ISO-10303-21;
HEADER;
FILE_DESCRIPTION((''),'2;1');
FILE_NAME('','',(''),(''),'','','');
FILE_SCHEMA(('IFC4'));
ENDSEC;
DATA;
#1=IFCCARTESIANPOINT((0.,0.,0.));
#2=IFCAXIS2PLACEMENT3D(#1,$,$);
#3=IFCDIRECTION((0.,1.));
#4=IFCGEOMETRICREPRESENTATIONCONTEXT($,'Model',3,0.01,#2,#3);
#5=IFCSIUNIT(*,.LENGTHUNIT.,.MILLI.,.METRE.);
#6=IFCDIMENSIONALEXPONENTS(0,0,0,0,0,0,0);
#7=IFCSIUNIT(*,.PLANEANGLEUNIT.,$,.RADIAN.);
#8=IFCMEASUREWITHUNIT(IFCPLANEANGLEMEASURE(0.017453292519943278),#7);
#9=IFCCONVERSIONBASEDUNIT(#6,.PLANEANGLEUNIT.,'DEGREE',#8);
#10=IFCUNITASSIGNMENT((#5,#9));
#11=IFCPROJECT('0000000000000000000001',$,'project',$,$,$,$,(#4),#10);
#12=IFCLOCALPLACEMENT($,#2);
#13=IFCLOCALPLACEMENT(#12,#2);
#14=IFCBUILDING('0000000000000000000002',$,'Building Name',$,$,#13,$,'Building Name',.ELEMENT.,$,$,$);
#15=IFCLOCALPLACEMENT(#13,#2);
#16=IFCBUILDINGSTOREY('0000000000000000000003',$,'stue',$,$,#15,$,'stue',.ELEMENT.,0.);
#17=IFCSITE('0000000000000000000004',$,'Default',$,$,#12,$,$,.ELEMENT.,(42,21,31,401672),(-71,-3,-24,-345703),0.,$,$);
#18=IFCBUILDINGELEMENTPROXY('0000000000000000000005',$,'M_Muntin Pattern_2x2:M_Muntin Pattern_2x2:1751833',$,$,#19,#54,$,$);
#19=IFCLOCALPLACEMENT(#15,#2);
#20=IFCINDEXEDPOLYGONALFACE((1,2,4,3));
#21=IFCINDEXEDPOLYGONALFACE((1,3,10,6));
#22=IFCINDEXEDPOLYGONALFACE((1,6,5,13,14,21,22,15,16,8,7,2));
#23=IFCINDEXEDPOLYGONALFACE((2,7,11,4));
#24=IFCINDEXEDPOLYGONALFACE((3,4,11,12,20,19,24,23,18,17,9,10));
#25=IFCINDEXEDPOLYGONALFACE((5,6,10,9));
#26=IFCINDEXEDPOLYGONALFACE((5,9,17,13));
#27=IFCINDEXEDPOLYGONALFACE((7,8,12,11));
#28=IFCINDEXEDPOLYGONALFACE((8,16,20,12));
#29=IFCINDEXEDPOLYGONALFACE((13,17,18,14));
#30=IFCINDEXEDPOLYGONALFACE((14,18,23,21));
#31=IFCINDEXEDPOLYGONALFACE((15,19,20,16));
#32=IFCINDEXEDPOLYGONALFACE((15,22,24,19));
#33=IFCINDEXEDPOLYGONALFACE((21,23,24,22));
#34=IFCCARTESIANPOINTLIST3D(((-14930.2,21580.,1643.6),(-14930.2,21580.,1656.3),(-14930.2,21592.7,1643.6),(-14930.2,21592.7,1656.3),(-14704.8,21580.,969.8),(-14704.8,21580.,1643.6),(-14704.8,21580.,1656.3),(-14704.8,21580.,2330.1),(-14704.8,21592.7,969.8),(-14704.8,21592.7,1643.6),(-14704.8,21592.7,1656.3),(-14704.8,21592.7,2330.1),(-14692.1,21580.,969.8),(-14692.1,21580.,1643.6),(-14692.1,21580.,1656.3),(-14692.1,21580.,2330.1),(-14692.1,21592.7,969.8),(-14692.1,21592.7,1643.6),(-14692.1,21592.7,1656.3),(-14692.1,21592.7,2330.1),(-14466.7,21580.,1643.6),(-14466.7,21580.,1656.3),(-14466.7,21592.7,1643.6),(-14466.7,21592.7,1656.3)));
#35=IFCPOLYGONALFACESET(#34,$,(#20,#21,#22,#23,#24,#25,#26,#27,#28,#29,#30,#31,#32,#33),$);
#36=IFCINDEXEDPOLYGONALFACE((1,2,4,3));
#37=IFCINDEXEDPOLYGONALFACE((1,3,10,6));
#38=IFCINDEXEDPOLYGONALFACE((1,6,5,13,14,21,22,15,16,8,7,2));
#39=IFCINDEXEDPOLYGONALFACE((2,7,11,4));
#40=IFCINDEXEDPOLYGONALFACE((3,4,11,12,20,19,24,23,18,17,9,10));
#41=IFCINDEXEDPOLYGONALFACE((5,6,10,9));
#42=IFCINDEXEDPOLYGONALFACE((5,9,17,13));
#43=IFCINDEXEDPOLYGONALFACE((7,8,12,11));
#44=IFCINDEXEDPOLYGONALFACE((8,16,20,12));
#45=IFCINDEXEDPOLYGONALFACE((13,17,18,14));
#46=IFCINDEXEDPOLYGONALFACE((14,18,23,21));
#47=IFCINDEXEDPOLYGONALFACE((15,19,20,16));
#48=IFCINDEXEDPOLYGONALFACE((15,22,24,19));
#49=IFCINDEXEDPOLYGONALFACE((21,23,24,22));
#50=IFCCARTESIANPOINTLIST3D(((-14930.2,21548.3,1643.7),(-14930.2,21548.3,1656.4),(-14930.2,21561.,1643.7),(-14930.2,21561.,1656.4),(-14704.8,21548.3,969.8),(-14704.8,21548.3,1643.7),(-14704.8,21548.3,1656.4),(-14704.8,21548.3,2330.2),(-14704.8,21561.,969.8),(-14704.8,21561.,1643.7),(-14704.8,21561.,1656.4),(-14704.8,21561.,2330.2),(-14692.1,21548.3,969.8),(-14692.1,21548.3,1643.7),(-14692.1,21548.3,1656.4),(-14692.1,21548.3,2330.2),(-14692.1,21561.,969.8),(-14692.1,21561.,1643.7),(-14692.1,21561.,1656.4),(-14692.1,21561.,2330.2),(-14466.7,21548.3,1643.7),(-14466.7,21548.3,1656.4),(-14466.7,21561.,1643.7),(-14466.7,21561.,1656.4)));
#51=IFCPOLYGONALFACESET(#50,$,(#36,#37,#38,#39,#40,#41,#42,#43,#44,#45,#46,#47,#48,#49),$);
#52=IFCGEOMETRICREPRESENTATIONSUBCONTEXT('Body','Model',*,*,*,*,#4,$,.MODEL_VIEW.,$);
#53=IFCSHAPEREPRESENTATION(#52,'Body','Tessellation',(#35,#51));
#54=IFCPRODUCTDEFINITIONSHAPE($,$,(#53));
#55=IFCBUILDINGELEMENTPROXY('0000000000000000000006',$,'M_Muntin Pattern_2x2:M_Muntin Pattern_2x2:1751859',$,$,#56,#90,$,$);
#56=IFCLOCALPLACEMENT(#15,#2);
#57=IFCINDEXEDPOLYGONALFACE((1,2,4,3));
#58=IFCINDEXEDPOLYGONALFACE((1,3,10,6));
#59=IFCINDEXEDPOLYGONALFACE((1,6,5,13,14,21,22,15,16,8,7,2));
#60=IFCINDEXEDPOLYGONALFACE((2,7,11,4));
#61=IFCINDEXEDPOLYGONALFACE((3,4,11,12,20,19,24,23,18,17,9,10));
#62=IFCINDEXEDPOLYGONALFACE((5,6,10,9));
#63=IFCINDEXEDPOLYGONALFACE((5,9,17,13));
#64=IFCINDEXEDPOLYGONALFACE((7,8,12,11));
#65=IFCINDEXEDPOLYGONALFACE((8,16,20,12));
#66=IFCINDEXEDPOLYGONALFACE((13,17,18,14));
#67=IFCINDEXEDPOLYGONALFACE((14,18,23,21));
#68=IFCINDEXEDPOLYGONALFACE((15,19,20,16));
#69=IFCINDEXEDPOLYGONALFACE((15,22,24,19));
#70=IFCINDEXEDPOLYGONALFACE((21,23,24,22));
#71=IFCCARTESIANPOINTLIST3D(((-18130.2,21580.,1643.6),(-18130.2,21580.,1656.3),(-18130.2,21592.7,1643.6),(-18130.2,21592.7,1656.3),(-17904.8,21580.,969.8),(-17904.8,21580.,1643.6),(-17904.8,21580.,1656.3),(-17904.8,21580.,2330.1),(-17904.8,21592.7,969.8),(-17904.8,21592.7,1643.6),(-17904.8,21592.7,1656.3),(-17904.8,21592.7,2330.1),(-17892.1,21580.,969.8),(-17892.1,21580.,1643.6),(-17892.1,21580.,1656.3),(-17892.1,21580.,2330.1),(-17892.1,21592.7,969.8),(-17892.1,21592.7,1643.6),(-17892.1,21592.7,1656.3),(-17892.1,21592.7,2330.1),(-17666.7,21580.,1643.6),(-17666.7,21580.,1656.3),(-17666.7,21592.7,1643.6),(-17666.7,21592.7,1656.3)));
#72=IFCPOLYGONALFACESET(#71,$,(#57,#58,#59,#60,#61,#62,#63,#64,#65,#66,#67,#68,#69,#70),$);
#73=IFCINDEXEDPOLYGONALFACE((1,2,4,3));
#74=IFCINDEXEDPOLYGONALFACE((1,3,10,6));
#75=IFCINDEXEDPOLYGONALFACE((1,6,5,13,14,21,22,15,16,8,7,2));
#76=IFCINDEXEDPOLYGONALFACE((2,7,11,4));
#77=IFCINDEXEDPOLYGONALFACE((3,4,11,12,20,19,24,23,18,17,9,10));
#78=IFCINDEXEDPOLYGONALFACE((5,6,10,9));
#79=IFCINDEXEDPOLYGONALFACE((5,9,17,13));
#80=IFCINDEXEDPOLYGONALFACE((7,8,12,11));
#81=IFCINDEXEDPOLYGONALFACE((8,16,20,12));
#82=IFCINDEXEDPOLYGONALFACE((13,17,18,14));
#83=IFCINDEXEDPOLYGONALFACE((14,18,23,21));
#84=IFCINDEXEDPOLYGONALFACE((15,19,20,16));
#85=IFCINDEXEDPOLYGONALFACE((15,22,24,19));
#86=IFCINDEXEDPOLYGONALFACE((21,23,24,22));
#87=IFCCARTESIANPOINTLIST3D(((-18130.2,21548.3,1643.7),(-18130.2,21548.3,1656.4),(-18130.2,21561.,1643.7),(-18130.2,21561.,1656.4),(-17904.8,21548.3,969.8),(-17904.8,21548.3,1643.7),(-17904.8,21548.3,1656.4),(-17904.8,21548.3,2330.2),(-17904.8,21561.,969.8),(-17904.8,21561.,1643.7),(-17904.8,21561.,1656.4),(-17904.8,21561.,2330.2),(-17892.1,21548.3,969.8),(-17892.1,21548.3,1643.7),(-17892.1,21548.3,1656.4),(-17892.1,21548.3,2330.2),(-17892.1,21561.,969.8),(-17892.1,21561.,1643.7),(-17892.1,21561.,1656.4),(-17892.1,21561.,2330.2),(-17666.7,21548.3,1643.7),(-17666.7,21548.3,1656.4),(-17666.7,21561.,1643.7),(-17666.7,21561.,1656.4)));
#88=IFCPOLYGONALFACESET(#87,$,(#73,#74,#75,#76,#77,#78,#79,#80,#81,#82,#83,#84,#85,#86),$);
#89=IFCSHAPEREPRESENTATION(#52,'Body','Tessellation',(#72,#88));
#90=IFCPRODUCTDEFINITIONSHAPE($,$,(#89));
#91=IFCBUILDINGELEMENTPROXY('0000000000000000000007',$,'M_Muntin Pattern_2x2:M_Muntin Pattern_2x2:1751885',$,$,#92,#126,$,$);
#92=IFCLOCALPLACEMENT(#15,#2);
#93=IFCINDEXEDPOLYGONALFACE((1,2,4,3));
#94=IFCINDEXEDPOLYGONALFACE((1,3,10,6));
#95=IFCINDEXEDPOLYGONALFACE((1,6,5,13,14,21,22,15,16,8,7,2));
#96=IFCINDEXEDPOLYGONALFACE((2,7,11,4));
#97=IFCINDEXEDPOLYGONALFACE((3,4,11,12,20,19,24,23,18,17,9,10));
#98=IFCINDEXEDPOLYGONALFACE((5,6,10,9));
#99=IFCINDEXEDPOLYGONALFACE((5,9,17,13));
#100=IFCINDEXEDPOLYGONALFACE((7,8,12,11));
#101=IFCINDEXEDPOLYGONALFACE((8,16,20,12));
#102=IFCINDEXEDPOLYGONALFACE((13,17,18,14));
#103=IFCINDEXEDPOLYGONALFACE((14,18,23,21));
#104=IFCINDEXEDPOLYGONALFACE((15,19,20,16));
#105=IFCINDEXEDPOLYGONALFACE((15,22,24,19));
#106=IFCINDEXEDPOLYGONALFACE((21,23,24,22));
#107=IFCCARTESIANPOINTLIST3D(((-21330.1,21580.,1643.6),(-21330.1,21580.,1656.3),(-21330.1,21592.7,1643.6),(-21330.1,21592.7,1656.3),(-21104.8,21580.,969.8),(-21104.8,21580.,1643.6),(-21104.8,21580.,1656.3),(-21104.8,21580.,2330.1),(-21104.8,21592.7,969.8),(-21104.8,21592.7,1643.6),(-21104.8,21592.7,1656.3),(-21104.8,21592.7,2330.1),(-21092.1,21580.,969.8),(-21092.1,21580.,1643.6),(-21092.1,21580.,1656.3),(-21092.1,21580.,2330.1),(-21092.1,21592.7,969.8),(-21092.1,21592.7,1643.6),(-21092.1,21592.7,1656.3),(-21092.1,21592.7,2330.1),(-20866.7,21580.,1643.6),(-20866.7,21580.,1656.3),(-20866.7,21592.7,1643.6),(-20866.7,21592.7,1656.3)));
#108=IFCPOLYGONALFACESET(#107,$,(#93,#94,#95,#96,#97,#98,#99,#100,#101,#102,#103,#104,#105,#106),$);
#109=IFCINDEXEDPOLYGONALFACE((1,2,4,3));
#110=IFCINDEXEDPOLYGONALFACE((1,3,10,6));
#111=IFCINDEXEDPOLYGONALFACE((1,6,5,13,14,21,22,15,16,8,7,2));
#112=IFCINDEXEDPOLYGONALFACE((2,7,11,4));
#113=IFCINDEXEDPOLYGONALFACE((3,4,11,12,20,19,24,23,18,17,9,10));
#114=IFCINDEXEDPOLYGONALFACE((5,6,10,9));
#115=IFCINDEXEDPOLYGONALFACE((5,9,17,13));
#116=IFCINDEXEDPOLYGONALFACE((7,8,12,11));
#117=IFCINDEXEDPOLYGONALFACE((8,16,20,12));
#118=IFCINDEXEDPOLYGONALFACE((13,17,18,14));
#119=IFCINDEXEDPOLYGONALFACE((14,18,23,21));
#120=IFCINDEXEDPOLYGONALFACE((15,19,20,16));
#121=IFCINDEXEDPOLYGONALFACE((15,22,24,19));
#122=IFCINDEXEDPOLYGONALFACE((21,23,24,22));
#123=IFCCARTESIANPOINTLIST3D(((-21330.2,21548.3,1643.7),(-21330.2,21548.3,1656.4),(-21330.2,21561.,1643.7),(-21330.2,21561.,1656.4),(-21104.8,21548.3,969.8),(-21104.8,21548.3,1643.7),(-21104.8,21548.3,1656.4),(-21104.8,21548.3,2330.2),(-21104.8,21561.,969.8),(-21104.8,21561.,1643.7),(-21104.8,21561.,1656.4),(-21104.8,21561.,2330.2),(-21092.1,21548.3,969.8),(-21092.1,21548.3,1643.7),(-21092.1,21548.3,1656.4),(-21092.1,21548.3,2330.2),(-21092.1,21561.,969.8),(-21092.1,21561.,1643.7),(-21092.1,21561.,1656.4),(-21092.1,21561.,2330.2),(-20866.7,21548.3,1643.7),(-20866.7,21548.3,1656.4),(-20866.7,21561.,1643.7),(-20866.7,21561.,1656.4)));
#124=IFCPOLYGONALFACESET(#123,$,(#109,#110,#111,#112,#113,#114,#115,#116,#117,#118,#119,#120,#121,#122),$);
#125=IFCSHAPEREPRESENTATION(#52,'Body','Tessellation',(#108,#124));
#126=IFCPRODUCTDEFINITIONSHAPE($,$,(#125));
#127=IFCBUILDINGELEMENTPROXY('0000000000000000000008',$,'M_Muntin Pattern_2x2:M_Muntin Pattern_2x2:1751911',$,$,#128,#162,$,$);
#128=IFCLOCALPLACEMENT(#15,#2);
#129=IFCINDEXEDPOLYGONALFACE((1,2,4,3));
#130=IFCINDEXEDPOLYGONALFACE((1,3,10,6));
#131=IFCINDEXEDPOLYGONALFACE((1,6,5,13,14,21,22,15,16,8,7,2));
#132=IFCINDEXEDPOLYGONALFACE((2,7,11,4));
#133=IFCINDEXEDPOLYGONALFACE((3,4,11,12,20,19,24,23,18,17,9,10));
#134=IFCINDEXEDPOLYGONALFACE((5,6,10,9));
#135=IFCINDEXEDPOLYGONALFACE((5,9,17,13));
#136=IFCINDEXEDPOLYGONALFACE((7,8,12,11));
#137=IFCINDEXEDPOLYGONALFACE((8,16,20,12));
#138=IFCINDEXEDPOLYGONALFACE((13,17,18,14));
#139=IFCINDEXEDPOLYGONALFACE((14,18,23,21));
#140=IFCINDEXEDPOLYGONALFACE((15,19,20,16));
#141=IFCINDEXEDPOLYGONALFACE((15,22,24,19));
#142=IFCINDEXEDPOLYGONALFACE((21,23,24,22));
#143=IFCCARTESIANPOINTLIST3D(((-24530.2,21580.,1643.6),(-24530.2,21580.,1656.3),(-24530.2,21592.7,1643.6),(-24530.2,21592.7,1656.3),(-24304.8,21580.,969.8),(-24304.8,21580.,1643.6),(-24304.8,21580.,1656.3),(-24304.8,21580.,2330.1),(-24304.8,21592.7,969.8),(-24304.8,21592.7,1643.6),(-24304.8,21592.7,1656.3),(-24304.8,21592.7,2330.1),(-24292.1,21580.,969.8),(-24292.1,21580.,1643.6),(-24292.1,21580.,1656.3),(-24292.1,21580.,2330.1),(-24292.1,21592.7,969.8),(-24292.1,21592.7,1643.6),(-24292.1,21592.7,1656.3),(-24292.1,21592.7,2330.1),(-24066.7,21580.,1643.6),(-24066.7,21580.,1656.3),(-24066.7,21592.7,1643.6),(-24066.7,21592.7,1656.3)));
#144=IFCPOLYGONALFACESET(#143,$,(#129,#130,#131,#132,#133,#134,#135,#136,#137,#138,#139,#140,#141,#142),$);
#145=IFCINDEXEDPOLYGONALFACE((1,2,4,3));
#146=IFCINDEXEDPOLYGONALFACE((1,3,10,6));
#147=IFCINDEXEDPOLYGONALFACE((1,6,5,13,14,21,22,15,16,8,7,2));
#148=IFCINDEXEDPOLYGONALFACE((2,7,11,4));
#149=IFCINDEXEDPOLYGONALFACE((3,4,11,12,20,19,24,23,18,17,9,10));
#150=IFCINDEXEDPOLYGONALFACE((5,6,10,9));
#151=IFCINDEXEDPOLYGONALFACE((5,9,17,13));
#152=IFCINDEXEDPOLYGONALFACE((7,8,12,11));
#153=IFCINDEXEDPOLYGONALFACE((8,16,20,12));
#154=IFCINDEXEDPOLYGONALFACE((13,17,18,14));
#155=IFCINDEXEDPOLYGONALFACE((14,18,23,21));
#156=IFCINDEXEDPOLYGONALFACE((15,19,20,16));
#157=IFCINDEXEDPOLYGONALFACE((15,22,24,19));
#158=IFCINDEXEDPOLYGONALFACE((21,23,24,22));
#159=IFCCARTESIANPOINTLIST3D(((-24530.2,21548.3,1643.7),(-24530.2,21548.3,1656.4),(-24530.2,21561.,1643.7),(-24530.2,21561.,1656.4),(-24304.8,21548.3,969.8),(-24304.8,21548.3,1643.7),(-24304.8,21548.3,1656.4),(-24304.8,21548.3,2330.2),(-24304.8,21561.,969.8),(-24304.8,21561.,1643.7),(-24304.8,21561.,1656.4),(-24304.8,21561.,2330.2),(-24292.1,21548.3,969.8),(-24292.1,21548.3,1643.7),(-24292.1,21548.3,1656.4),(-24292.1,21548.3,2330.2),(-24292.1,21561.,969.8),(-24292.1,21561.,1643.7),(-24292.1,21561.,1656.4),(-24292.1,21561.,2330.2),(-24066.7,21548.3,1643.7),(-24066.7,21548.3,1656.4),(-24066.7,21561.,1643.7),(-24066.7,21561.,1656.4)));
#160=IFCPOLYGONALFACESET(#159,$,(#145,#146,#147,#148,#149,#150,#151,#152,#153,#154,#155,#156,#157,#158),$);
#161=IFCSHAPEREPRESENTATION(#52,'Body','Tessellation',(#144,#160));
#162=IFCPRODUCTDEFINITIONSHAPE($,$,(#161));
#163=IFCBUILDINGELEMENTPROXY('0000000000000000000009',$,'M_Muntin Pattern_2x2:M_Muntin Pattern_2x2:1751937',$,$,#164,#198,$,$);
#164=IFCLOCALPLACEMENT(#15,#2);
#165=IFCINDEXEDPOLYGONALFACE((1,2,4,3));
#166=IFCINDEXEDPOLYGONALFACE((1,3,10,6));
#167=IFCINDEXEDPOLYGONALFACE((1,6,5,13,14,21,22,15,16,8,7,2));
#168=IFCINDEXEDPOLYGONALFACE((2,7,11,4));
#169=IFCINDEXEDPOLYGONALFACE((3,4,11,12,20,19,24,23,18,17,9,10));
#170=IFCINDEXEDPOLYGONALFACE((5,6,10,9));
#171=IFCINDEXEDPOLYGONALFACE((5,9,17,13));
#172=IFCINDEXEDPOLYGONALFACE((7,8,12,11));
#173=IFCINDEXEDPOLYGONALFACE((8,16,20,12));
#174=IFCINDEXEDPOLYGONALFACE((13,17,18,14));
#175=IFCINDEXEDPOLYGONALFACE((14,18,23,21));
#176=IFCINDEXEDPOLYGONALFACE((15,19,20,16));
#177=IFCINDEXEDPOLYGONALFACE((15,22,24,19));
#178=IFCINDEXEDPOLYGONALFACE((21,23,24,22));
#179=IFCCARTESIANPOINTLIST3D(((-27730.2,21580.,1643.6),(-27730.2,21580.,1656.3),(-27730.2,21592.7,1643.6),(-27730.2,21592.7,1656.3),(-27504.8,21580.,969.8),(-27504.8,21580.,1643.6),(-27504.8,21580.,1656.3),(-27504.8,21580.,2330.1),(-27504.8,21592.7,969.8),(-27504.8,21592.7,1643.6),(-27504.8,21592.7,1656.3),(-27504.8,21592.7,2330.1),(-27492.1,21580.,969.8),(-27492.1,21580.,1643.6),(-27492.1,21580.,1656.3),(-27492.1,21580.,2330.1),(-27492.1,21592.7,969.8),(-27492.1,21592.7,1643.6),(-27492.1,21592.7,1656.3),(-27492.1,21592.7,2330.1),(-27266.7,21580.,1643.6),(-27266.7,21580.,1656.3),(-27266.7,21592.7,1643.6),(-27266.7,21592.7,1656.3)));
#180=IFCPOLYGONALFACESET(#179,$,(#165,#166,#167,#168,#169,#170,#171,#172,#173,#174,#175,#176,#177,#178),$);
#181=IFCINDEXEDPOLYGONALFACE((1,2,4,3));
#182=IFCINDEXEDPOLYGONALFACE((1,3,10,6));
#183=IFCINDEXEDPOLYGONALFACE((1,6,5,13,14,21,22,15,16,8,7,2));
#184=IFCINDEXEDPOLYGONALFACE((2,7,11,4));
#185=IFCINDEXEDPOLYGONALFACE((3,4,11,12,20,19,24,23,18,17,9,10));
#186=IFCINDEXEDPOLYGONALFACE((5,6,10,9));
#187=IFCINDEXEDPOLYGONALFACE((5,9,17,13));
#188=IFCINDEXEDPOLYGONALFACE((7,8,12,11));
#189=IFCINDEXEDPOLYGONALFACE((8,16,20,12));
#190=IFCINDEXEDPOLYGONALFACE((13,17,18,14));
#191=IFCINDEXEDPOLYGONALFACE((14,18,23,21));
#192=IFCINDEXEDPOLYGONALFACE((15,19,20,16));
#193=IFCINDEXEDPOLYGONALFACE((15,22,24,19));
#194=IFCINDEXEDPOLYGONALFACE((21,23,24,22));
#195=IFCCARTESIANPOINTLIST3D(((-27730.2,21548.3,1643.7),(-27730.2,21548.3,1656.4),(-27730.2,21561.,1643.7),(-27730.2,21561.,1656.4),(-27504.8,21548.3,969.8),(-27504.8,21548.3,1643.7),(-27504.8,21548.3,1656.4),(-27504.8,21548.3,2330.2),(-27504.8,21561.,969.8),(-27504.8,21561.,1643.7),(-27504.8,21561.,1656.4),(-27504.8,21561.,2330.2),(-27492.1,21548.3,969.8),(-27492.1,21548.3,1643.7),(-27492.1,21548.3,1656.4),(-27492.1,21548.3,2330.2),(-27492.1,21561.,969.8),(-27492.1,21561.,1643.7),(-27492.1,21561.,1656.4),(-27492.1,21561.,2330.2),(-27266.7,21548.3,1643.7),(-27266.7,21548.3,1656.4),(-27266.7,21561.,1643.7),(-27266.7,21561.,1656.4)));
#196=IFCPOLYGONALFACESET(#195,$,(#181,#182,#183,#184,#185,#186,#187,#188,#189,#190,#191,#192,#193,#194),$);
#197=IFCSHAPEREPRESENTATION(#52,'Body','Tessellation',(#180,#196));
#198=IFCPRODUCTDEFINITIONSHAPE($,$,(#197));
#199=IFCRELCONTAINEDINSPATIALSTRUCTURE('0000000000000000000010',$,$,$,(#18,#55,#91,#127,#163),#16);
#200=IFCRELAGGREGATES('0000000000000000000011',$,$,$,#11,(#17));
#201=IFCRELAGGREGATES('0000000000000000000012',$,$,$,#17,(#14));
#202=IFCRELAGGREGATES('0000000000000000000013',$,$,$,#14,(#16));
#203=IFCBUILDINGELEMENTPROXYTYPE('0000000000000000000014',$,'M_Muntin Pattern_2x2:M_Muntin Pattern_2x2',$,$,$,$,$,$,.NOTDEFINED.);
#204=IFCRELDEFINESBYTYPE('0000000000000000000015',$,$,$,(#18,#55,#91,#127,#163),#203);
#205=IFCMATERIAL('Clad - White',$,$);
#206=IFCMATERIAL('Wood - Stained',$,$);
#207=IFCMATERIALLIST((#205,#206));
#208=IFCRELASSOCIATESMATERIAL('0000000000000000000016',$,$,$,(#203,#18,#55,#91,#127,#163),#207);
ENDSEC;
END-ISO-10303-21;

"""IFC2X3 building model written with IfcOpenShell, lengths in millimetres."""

from ifc_helpers import new_model, entity, si_unit, converted_unit, direction, frame, origin, place, context, subcontext, project, spatial, polyline, outline, extrude, source, transform, mapped, material, material_list, type_object, type_shapes, element, save


model = new_model("IFC2X3")

# Units and contexts
model_context = context("Model", 3, precision=0.01, world=origin(), true_north=direction((0.0, 1.0)))
body_context = subcontext(model_context, "Body", "Model", "MODEL_VIEW")
ifc_project = project(units=[si_unit("LENGTHUNIT", "METRE", prefix="MILLI"), converted_unit("PLANEANGLEUNIT", "DEGREE", entity("IfcPlaneAngleMeasure", 0.017453292519943278), si_unit("PLANEANGLEUNIT", "RADIAN"), dimensions=[0, 0, 0, 0, 0, 0, 0])], contexts=[model_context])

# Site, building, storey
site_placement = place(None, origin())
site = spatial("IfcSite", under=ifc_project, at=site_placement, Name="Default", CompositionType="ELEMENT", RefLatitude=(42, 21, 31, 401672), RefLongitude=(-71, -3, -24, -345703), RefElevation=0.0)
building_placement = place(site_placement, origin())
building = spatial("IfcBuilding", under=site, at=building_placement, Name="Building Name", LongName="Building Name", CompositionType="ELEMENT")
storey_placement = place(building_placement, origin())
storey = spatial("IfcBuildingStorey", under=building, at=storey_placement, Name="stue", LongName="stue", CompositionType="ELEMENT", Elevation=0.0)

# Building element proxies
ifc_material_1 = material(Name="Clad - White")
ifc_material_2 = material(Name="Wood - Stained")
ifc_material_list = material_list([ifc_material_1, ifc_material_2])
building_element_proxy_type_1 = type_object("IfcBuildingElementProxyType", Name="M_Muntin Pattern_2x2:M_Muntin Pattern_2x2", PredefinedType="NOTDEFINED", material=ifc_material_list)
shared_shape_1 = source(origin(), body_context, "Body", "SweptSolid", [
    extrude(outline(polyline([(6.4, -6.4), (680.1, -6.4), (680.1, 6.3), (6.4, 6.3), (6.4, 231.7), (-6.3, 231.7), (-6.3, 6.3), (-680.2, 6.3), (-680.2, -6.4), (-6.3, -6.4), (-6.3, -231.7), (6.4, -231.7), (6.4, -6.4)])), frame((0.0, 9.5, 680.1), z_axis=(0.0, 1.0, 0.0), x_axis=(0.0, 0.0, 1.0)), (0.0, 0.0, 1.0), 12.7),
    extrude(outline(polyline([(6.4, -6.4), (680.2, -6.4), (680.2, 6.3), (6.4, 6.3), (6.4, 231.7), (-6.3, 231.7), (-6.3, 6.3), (-680.2, 6.3), (-680.2, -6.4), (-6.3, -6.4), (-6.3, -231.7), (6.4, -231.7), (6.4, -6.4)])), frame((0.0, -22.2, 680.2), z_axis=(0.0, 1.0, 0.0), x_axis=(0.0, 0.0, 1.0)), (0.0, 0.0, 1.0), 12.7),
])
type_shapes(building_element_proxy_type_1, [shared_shape_1])
for number, where, name in (
    (1, (-14698.4, 21570.5, 969.8), "M_Muntin Pattern_2x2:M_Muntin Pattern_2x2:1751833"),
    (2, (-17898.4, 21570.5, 969.8), "M_Muntin Pattern_2x2:M_Muntin Pattern_2x2:1751859"),
    (3, (-21098.4, 21570.5, 969.8), "M_Muntin Pattern_2x2:M_Muntin Pattern_2x2:1751885"),
    (4, (-24298.4, 21570.5, 969.8), "M_Muntin Pattern_2x2:M_Muntin Pattern_2x2:1751911"),
    (5, (-27498.4, 21570.5, 969.8), "M_Muntin Pattern_2x2:M_Muntin Pattern_2x2:1751937"),
):
    element("IfcBuildingElementProxy", number, at=place(storey_placement, frame(where)), inside=storey, type_object=building_element_proxy_type_1, material=ifc_material_list, Name=name, context=body_context, shape_type="MappedRepresentation", body=[
        mapped(shared_shape_1, transform((0.0, 0.0, 0.0), scale=1.0)),
    ])

save(model, "model.ifc")
